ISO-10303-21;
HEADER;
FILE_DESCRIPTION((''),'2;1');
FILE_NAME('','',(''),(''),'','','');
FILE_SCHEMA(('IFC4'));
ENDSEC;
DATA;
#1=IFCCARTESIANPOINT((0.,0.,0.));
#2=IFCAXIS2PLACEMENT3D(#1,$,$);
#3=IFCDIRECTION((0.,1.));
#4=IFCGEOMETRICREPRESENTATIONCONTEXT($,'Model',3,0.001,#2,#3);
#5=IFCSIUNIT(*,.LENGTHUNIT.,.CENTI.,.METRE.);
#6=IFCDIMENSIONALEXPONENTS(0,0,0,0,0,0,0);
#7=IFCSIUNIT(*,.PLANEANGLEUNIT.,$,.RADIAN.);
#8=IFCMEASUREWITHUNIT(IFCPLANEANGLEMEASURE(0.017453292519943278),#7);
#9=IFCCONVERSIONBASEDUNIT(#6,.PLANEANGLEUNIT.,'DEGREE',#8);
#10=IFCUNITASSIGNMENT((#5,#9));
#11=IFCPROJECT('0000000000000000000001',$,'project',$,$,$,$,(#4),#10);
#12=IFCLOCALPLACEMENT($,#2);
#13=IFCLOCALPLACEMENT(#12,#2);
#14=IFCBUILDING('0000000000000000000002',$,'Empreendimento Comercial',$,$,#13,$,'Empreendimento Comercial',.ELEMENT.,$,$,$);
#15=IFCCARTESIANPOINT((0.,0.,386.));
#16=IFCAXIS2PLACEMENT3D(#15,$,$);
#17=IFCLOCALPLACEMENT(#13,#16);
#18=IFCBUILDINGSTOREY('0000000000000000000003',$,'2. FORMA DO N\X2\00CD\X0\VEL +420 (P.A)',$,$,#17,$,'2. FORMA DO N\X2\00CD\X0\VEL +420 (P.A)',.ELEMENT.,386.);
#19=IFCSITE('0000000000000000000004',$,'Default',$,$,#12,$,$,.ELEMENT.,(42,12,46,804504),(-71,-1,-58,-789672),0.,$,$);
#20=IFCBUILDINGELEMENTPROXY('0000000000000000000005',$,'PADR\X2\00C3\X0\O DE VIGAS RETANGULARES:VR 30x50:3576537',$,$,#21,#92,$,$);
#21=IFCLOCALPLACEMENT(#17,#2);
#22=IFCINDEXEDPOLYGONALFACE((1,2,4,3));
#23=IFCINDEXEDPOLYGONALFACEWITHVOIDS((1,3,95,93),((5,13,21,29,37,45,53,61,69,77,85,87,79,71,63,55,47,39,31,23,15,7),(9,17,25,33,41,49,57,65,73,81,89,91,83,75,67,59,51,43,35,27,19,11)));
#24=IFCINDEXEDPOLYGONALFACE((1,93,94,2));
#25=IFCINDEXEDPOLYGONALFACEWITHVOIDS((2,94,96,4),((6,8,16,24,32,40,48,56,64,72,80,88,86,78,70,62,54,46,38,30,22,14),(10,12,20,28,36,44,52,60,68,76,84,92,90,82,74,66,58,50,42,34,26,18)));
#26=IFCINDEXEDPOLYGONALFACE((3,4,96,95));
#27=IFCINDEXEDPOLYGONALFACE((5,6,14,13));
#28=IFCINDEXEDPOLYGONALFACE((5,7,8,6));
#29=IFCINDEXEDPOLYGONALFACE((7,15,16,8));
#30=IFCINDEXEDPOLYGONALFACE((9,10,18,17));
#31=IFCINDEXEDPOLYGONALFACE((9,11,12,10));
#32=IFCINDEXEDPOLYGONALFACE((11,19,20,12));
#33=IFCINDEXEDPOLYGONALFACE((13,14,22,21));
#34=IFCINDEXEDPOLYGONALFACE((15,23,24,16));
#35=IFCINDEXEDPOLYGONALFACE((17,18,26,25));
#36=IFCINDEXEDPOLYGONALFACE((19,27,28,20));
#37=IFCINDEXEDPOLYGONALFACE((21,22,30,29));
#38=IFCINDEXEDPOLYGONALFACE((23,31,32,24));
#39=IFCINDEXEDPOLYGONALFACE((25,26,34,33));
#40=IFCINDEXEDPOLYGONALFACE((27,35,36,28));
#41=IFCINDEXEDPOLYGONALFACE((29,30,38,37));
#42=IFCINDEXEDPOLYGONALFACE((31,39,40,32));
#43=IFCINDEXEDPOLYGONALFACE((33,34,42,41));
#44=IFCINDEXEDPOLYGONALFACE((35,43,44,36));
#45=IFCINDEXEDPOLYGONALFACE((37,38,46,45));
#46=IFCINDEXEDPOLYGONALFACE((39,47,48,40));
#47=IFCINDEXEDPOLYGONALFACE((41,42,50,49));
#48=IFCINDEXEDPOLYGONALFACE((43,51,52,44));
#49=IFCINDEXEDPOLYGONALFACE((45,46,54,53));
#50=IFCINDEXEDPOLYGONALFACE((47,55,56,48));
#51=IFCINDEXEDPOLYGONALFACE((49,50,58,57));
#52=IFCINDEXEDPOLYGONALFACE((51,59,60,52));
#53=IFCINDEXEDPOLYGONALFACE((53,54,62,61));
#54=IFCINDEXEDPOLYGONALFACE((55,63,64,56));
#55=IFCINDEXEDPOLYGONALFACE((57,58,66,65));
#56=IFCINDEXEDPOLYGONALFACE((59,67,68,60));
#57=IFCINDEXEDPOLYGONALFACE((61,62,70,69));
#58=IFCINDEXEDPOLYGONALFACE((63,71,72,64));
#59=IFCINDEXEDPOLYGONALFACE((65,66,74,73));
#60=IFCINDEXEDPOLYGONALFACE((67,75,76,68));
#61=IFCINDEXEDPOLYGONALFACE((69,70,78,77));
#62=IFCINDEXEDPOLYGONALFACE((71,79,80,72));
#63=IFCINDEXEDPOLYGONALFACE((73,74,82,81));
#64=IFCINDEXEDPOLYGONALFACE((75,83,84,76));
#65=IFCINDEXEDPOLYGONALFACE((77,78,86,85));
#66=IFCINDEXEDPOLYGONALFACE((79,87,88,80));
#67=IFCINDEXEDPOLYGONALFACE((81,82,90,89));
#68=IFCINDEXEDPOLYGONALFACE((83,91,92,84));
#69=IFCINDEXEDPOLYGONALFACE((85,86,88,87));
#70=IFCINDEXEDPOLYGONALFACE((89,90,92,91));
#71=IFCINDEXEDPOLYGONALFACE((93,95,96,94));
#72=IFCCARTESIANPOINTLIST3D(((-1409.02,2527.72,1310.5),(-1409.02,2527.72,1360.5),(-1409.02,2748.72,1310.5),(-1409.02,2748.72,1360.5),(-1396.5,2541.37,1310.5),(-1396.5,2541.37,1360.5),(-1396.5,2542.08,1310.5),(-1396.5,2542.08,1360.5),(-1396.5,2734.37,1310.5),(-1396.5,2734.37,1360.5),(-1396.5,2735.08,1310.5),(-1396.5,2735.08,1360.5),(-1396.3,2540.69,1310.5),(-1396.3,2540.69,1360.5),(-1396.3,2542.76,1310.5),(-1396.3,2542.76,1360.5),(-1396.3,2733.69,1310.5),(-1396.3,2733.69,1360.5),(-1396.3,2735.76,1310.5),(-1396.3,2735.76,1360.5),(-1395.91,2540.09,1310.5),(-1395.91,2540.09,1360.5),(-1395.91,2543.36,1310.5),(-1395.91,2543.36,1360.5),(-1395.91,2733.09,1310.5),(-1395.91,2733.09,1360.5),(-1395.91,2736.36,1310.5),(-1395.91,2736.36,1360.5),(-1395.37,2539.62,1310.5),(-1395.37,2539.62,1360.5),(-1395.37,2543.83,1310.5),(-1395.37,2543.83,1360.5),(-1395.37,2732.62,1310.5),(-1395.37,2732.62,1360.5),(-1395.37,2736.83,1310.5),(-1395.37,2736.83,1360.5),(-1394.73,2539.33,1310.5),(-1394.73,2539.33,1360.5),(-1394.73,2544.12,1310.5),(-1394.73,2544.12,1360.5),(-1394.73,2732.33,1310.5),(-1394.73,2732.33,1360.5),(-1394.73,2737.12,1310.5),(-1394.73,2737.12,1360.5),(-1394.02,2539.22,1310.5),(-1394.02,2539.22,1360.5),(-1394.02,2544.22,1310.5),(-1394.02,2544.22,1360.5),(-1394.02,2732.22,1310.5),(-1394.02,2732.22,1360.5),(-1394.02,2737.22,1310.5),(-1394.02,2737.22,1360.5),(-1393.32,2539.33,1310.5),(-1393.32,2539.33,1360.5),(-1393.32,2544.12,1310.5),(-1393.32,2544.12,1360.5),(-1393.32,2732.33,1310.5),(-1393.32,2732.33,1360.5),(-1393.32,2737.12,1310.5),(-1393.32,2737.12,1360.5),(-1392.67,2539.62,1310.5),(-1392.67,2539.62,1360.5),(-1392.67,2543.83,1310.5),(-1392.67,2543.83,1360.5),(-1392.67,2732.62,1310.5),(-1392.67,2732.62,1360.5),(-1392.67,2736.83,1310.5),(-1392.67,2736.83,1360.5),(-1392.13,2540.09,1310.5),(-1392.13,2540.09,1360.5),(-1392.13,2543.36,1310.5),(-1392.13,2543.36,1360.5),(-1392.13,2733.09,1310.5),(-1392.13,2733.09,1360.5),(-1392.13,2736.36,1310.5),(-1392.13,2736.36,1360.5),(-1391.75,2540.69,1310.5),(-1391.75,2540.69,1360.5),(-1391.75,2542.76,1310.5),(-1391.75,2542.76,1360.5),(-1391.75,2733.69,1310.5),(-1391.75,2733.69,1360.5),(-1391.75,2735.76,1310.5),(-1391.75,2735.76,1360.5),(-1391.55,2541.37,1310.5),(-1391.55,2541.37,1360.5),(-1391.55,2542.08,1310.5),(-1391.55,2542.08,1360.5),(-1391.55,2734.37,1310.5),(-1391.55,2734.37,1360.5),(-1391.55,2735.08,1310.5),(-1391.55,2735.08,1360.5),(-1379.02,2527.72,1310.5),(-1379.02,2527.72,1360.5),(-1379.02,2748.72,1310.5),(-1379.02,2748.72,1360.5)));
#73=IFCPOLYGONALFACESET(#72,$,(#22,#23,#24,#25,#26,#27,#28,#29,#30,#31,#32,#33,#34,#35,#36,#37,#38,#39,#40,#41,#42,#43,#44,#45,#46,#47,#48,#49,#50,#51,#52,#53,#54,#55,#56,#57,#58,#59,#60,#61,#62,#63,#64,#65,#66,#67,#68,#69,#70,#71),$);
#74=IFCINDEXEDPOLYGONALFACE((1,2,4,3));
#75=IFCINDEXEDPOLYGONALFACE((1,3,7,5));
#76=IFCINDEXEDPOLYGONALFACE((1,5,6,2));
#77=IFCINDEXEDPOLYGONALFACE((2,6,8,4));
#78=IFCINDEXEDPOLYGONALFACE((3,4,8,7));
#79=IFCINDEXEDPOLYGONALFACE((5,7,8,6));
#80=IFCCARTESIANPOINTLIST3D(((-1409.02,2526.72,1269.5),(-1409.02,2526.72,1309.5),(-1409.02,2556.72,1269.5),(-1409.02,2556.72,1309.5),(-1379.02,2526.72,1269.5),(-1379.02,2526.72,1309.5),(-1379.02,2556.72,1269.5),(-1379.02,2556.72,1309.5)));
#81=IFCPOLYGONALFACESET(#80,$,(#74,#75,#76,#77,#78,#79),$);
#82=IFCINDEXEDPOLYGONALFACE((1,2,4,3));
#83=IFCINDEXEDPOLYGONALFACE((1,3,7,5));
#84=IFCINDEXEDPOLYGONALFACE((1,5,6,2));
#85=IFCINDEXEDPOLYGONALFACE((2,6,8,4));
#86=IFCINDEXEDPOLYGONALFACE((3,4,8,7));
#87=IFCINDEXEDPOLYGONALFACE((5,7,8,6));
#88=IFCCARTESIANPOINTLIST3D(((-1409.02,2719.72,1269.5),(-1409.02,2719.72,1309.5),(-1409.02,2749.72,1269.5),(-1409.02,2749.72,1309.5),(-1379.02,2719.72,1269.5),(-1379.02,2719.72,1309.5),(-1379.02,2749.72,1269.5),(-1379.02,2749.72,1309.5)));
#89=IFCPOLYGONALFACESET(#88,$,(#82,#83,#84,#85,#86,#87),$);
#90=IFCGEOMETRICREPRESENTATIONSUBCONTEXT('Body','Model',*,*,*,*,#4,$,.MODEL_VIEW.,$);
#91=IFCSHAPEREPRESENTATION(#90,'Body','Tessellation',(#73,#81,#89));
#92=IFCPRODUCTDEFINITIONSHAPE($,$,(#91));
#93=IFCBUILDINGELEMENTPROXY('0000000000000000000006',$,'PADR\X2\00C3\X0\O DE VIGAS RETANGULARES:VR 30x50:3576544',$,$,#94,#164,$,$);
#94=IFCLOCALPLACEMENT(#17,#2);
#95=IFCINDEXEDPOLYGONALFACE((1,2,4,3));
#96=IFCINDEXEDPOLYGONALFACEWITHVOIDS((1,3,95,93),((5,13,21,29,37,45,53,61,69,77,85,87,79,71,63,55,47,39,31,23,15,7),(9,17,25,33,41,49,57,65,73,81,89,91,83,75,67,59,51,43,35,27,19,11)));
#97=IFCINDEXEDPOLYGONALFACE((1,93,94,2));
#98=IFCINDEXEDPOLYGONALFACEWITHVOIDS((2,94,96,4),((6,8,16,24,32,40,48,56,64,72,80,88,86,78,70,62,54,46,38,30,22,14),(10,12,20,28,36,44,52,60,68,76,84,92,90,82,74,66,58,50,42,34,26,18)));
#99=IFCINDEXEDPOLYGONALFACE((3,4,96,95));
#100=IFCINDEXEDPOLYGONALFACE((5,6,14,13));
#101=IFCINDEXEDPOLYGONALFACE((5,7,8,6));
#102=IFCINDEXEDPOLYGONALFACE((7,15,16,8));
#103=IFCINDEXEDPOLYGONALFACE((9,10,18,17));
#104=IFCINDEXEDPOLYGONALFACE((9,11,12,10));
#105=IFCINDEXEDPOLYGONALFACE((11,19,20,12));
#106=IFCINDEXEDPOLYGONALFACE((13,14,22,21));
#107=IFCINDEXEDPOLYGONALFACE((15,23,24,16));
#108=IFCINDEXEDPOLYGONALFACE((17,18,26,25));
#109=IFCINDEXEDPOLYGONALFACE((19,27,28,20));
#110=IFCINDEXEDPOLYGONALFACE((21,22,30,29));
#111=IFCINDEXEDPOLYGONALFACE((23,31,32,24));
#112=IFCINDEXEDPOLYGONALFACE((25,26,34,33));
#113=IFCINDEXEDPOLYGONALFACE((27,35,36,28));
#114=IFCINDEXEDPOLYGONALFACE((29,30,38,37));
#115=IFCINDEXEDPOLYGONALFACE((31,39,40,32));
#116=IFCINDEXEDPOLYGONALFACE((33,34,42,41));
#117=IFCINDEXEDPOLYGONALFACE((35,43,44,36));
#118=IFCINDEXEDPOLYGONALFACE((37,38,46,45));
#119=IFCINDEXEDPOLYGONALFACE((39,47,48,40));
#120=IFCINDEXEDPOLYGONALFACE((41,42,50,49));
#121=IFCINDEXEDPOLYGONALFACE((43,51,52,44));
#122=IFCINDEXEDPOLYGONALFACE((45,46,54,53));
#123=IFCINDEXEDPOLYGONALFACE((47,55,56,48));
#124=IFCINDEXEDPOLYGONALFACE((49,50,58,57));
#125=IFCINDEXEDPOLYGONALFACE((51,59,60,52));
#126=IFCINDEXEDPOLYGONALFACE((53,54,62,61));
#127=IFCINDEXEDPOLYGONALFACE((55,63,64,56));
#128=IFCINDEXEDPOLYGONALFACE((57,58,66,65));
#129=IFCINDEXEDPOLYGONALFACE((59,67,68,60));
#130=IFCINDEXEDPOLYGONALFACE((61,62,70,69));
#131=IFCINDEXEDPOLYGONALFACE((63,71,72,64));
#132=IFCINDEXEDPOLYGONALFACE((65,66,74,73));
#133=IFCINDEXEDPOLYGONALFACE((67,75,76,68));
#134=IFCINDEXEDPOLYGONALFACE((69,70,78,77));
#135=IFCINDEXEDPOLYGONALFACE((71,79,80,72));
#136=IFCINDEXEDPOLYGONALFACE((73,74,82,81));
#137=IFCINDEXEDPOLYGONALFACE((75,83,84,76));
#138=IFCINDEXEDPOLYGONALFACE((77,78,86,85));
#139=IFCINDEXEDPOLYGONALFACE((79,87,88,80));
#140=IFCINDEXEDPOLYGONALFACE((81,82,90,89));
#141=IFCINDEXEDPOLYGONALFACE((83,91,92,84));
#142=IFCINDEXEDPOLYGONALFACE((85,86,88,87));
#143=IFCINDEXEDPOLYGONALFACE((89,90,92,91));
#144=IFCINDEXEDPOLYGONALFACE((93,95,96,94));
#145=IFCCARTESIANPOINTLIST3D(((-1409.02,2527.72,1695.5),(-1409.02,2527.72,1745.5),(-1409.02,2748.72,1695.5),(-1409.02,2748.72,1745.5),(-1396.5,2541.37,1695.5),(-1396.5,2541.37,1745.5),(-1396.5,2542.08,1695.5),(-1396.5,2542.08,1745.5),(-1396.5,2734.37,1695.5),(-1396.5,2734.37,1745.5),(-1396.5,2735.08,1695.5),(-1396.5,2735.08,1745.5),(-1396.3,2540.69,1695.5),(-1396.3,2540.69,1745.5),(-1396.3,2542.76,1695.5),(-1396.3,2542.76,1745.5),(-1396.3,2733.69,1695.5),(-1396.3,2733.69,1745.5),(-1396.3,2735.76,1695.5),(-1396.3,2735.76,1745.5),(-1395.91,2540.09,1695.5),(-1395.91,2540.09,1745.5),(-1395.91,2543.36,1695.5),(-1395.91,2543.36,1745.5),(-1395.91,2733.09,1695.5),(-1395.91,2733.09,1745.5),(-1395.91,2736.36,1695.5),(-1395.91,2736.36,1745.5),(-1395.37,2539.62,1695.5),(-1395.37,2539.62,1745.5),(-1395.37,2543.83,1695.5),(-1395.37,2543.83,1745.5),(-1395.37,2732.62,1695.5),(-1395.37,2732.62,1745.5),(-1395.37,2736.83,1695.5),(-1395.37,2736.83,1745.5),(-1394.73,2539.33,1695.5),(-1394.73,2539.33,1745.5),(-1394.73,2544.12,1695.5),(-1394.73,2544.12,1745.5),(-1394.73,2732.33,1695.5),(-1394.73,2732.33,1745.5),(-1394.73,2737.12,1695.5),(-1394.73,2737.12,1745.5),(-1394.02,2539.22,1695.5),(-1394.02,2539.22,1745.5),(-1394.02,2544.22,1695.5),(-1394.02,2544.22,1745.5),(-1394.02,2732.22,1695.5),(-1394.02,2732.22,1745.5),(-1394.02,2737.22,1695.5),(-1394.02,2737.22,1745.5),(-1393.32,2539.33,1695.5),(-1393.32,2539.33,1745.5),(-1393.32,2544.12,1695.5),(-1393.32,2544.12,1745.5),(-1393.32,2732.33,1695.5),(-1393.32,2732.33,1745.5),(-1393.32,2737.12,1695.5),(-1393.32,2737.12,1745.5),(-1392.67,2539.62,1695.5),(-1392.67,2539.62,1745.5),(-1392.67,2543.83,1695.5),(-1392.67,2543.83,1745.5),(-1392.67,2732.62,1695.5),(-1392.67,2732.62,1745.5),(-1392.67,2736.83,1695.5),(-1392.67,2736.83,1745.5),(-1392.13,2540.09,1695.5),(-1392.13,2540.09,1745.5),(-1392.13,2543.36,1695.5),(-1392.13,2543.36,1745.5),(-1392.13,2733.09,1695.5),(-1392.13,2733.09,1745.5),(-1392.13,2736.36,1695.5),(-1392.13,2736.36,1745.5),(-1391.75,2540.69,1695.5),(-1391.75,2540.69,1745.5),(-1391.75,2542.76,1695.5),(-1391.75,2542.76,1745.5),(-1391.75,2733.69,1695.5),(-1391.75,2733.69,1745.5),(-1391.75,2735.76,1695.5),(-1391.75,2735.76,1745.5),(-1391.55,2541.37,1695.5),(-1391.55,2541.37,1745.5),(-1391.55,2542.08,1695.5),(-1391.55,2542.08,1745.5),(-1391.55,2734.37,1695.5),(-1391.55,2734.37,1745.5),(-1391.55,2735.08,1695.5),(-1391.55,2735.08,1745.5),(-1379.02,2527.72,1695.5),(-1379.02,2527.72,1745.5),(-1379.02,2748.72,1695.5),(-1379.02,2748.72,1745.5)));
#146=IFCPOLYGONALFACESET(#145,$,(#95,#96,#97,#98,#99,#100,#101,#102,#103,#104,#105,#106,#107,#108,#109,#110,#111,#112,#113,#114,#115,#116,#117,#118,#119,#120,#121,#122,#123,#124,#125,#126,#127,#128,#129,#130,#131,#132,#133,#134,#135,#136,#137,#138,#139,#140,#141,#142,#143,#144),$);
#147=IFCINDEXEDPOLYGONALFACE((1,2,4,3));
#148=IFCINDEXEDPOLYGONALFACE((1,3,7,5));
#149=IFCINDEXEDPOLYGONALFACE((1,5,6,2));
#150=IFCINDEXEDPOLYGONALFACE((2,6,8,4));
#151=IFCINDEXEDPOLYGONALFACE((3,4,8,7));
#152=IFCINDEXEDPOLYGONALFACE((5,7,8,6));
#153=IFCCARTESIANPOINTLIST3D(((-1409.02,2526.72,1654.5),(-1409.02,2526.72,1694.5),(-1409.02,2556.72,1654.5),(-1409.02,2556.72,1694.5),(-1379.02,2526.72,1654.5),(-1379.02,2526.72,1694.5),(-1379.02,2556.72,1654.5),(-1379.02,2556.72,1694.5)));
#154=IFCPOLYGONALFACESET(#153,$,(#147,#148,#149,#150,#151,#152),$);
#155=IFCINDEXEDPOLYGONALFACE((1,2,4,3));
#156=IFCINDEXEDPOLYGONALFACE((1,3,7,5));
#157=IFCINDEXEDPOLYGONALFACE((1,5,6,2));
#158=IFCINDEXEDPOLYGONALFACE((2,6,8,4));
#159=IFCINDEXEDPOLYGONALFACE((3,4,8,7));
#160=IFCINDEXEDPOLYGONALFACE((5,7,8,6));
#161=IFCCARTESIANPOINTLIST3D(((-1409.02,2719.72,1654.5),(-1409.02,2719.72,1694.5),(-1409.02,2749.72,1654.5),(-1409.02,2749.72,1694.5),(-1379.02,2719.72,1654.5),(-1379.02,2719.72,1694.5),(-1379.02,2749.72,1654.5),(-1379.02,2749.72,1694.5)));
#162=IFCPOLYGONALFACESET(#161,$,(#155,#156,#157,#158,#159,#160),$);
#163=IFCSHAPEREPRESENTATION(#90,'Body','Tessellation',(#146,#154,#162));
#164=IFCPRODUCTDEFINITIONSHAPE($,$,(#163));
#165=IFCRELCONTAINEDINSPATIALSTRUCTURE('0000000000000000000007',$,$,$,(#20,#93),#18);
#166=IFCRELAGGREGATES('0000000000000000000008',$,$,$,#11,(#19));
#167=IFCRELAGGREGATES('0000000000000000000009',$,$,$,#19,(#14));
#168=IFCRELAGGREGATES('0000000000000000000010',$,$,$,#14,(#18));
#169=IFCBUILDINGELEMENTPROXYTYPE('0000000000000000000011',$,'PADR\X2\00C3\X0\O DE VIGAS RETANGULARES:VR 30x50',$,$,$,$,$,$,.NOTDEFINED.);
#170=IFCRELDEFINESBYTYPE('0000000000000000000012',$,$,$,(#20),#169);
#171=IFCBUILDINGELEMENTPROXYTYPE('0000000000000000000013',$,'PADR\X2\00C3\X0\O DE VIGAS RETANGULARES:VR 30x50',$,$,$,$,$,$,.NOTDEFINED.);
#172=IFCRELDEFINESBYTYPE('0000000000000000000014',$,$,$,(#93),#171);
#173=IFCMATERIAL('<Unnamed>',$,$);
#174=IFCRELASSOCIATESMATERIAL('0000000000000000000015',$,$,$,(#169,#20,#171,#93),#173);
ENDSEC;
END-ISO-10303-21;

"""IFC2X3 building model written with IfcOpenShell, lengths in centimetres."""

from ifc_helpers import new_model, entity, si_unit, converted_unit, direction, frame, frame_2d, origin, place, context, subcontext, project, spatial, polyline, circle_curve, parameter, trimmed, segment, composite_curve, rectangle, outline, extrude, source, transform, mapped, material, type_object, type_shapes, element, save


model = new_model("IFC2X3")

# Units and contexts
model_context = context("Model", 3, precision=0.001, world=origin(), true_north=direction((0.0, 1.0)))
body_context = subcontext(model_context, "Body", "Model", "MODEL_VIEW")
ifc_project = project(units=[si_unit("LENGTHUNIT", "METRE", prefix="CENTI"), converted_unit("PLANEANGLEUNIT", "DEGREE", entity("IfcPlaneAngleMeasure", 0.017453292519943278), si_unit("PLANEANGLEUNIT", "RADIAN"), dimensions=[0, 0, 0, 0, 0, 0, 0])], contexts=[model_context])

# Site, building, storey
site_placement = place(None, origin())
site = spatial("IfcSite", under=ifc_project, at=site_placement, Name="Default", CompositionType="ELEMENT", RefLatitude=(42, 12, 46, 804504), RefLongitude=(-71, -1, -58, -789672), RefElevation=0.0)
building_placement = place(site_placement, origin())
building = spatial("IfcBuilding", under=site, at=building_placement, Name="Empreendimento Comercial", LongName="Empreendimento Comercial", CompositionType="ELEMENT")
storey_placement = place(building_placement, frame((0.0, 0.0, 386.0)))
storey = spatial("IfcBuildingStorey", under=building, at=storey_placement, Name="2. FORMA DO NÍVEL +420 (P.A)", LongName="2. FORMA DO NÍVEL +420 (P.A)", CompositionType="ELEMENT", Elevation=386.0)

# Shared definitions
ifc_material_1 = material(Name="<Unnamed>")

# Building element proxies
building_element_proxy_type_1 = type_object("IfcBuildingElementProxyType", Name="PADRÃO DE VIGAS RETANGULARES:VR 30x50", PredefinedType="NOTDEFINED", material=ifc_material_1)
shared_shape_1 = source(origin(), body_context, "Body", "SweptSolid", [
    extrude(outline(polyline([(-110.5, -15.0), (110.5, -15.0), (110.5, 15.0), (-110.5, 15.0), (-110.5, -15.0)]), holes=[composite_curve([segment(trimmed(circle_curve(frame_2d((96.5, 0.0), x_axis=(-1.0, 0.0)), 2.5), [parameter(0.0)], [parameter(180.0)], True, "PARAMETER"), False, "CONTINUOUS"), segment(trimmed(circle_curve(frame_2d((96.5, 0.0), x_axis=(-1.0, 0.0)), 2.5), [parameter(180.0)], [parameter(0.0)], True, "PARAMETER"), False, "CONTINUOUS")], self_intersect=False), composite_curve([segment(trimmed(circle_curve(frame_2d((-96.5, 0.0), x_axis=(-1.0, 0.0)), 2.5), [parameter(0.0)], [parameter(180.0)], True, "PARAMETER"), False, "CONTINUOUS"), segment(trimmed(circle_curve(frame_2d((-96.5, 0.0), x_axis=(-1.0, 0.0)), 2.5), [parameter(180.0)], [parameter(0.0)], True, "PARAMETER"), False, "CONTINUOUS")], self_intersect=False)]), frame((-1394.02, 2638.22, 1696.5), z_axis=(0.0, 0.0, 1.0), x_axis=(0.0, -1.0, 0.0)), (0.0, 0.0, 1.0), 50.0),
    extrude(rectangle(XDim=30.0, YDim=30.0, at=frame_2d((0.0, 0.0), x_axis=(1.0, 0.0))), frame((-1394.02, 2541.72, 1655.5), z_axis=(0.0, 0.0, 1.0), x_axis=(-1.0, 0.0, 0.0)), (0.0, 0.0, 1.0), 40.0),
    extrude(rectangle(XDim=30.0, YDim=30.0, at=frame_2d((0.0, 0.0), x_axis=(1.0, 0.0))), frame((-1394.02, 2734.72, 1655.5), z_axis=(0.0, 0.0, 1.0), x_axis=(-1.0, 0.0, 0.0)), (0.0, 0.0, 1.0), 40.0),
])
type_shapes(building_element_proxy_type_1, [shared_shape_1])
proxy_1_placement = place(storey_placement, frame((0.0, 0.0, -386.0)))
element("IfcBuildingElementProxy", 1, at=proxy_1_placement, inside=storey, type_object=building_element_proxy_type_1, material=ifc_material_1, Name="PADRÃO DE VIGAS RETANGULARES:VR 30x50:3576537", context=body_context, shape_type="MappedRepresentation", body=[
    mapped(shared_shape_1, transform((0.0, 0.0, 0.0), scale=1.0)),
])
building_element_proxy_type_2 = type_object("IfcBuildingElementProxyType", Name="PADRÃO DE VIGAS RETANGULARES:VR 30x50", PredefinedType="NOTDEFINED", material=ifc_material_1)
shared_shape_2 = source(origin(), body_context, "Body", "SweptSolid", [
    extrude(outline(polyline([(-110.5, -15.0), (110.5, -15.0), (110.5, 15.0), (-110.5, 15.0), (-110.5, -15.0)]), holes=[composite_curve([segment(trimmed(circle_curve(frame_2d((96.5, 0.0), x_axis=(-1.0, 0.0)), 2.5), [parameter(0.0)], [parameter(180.0)], True, "PARAMETER"), False, "CONTINUOUS"), segment(trimmed(circle_curve(frame_2d((96.5, 0.0), x_axis=(-1.0, 0.0)), 2.5), [parameter(180.0)], [parameter(0.0)], True, "PARAMETER"), False, "CONTINUOUS")], self_intersect=False), composite_curve([segment(trimmed(circle_curve(frame_2d((-96.5, 0.0), x_axis=(-1.0, 0.0)), 2.5), [parameter(0.0)], [parameter(180.0)], True, "PARAMETER"), False, "CONTINUOUS"), segment(trimmed(circle_curve(frame_2d((-96.5, 0.0), x_axis=(-1.0, 0.0)), 2.5), [parameter(180.0)], [parameter(0.0)], True, "PARAMETER"), False, "CONTINUOUS")], self_intersect=False)]), frame((-1394.02, 2638.22, 2081.5), z_axis=(0.0, 0.0, 1.0), x_axis=(0.0, -1.0, 0.0)), (0.0, 0.0, 1.0), 50.0),
    extrude(rectangle(XDim=30.0, YDim=30.0, at=frame_2d((0.0, 0.0), x_axis=(1.0, 0.0))), frame((-1394.02, 2541.72, 2040.5), z_axis=(0.0, 0.0, 1.0), x_axis=(-1.0, 0.0, 0.0)), (0.0, 0.0, 1.0), 40.0),
    extrude(rectangle(XDim=30.0, YDim=30.0, at=frame_2d((0.0, 0.0), x_axis=(1.0, 0.0))), frame((-1394.02, 2734.72, 2040.5), z_axis=(0.0, 0.0, 1.0), x_axis=(-1.0, 0.0, 0.0)), (0.0, 0.0, 1.0), 40.0),
])
type_shapes(building_element_proxy_type_2, [shared_shape_2])
proxy_2_placement = place(storey_placement, frame((0.0, 0.0, -386.0)))
element("IfcBuildingElementProxy", 2, at=proxy_2_placement, inside=storey, type_object=building_element_proxy_type_2, material=ifc_material_1, Name="PADRÃO DE VIGAS RETANGULARES:VR 30x50:3576544", context=body_context, shape_type="MappedRepresentation", body=[
    mapped(shared_shape_2, transform((0.0, 0.0, 0.0), scale=1.0)),
])

save(model, "model.ifc")
